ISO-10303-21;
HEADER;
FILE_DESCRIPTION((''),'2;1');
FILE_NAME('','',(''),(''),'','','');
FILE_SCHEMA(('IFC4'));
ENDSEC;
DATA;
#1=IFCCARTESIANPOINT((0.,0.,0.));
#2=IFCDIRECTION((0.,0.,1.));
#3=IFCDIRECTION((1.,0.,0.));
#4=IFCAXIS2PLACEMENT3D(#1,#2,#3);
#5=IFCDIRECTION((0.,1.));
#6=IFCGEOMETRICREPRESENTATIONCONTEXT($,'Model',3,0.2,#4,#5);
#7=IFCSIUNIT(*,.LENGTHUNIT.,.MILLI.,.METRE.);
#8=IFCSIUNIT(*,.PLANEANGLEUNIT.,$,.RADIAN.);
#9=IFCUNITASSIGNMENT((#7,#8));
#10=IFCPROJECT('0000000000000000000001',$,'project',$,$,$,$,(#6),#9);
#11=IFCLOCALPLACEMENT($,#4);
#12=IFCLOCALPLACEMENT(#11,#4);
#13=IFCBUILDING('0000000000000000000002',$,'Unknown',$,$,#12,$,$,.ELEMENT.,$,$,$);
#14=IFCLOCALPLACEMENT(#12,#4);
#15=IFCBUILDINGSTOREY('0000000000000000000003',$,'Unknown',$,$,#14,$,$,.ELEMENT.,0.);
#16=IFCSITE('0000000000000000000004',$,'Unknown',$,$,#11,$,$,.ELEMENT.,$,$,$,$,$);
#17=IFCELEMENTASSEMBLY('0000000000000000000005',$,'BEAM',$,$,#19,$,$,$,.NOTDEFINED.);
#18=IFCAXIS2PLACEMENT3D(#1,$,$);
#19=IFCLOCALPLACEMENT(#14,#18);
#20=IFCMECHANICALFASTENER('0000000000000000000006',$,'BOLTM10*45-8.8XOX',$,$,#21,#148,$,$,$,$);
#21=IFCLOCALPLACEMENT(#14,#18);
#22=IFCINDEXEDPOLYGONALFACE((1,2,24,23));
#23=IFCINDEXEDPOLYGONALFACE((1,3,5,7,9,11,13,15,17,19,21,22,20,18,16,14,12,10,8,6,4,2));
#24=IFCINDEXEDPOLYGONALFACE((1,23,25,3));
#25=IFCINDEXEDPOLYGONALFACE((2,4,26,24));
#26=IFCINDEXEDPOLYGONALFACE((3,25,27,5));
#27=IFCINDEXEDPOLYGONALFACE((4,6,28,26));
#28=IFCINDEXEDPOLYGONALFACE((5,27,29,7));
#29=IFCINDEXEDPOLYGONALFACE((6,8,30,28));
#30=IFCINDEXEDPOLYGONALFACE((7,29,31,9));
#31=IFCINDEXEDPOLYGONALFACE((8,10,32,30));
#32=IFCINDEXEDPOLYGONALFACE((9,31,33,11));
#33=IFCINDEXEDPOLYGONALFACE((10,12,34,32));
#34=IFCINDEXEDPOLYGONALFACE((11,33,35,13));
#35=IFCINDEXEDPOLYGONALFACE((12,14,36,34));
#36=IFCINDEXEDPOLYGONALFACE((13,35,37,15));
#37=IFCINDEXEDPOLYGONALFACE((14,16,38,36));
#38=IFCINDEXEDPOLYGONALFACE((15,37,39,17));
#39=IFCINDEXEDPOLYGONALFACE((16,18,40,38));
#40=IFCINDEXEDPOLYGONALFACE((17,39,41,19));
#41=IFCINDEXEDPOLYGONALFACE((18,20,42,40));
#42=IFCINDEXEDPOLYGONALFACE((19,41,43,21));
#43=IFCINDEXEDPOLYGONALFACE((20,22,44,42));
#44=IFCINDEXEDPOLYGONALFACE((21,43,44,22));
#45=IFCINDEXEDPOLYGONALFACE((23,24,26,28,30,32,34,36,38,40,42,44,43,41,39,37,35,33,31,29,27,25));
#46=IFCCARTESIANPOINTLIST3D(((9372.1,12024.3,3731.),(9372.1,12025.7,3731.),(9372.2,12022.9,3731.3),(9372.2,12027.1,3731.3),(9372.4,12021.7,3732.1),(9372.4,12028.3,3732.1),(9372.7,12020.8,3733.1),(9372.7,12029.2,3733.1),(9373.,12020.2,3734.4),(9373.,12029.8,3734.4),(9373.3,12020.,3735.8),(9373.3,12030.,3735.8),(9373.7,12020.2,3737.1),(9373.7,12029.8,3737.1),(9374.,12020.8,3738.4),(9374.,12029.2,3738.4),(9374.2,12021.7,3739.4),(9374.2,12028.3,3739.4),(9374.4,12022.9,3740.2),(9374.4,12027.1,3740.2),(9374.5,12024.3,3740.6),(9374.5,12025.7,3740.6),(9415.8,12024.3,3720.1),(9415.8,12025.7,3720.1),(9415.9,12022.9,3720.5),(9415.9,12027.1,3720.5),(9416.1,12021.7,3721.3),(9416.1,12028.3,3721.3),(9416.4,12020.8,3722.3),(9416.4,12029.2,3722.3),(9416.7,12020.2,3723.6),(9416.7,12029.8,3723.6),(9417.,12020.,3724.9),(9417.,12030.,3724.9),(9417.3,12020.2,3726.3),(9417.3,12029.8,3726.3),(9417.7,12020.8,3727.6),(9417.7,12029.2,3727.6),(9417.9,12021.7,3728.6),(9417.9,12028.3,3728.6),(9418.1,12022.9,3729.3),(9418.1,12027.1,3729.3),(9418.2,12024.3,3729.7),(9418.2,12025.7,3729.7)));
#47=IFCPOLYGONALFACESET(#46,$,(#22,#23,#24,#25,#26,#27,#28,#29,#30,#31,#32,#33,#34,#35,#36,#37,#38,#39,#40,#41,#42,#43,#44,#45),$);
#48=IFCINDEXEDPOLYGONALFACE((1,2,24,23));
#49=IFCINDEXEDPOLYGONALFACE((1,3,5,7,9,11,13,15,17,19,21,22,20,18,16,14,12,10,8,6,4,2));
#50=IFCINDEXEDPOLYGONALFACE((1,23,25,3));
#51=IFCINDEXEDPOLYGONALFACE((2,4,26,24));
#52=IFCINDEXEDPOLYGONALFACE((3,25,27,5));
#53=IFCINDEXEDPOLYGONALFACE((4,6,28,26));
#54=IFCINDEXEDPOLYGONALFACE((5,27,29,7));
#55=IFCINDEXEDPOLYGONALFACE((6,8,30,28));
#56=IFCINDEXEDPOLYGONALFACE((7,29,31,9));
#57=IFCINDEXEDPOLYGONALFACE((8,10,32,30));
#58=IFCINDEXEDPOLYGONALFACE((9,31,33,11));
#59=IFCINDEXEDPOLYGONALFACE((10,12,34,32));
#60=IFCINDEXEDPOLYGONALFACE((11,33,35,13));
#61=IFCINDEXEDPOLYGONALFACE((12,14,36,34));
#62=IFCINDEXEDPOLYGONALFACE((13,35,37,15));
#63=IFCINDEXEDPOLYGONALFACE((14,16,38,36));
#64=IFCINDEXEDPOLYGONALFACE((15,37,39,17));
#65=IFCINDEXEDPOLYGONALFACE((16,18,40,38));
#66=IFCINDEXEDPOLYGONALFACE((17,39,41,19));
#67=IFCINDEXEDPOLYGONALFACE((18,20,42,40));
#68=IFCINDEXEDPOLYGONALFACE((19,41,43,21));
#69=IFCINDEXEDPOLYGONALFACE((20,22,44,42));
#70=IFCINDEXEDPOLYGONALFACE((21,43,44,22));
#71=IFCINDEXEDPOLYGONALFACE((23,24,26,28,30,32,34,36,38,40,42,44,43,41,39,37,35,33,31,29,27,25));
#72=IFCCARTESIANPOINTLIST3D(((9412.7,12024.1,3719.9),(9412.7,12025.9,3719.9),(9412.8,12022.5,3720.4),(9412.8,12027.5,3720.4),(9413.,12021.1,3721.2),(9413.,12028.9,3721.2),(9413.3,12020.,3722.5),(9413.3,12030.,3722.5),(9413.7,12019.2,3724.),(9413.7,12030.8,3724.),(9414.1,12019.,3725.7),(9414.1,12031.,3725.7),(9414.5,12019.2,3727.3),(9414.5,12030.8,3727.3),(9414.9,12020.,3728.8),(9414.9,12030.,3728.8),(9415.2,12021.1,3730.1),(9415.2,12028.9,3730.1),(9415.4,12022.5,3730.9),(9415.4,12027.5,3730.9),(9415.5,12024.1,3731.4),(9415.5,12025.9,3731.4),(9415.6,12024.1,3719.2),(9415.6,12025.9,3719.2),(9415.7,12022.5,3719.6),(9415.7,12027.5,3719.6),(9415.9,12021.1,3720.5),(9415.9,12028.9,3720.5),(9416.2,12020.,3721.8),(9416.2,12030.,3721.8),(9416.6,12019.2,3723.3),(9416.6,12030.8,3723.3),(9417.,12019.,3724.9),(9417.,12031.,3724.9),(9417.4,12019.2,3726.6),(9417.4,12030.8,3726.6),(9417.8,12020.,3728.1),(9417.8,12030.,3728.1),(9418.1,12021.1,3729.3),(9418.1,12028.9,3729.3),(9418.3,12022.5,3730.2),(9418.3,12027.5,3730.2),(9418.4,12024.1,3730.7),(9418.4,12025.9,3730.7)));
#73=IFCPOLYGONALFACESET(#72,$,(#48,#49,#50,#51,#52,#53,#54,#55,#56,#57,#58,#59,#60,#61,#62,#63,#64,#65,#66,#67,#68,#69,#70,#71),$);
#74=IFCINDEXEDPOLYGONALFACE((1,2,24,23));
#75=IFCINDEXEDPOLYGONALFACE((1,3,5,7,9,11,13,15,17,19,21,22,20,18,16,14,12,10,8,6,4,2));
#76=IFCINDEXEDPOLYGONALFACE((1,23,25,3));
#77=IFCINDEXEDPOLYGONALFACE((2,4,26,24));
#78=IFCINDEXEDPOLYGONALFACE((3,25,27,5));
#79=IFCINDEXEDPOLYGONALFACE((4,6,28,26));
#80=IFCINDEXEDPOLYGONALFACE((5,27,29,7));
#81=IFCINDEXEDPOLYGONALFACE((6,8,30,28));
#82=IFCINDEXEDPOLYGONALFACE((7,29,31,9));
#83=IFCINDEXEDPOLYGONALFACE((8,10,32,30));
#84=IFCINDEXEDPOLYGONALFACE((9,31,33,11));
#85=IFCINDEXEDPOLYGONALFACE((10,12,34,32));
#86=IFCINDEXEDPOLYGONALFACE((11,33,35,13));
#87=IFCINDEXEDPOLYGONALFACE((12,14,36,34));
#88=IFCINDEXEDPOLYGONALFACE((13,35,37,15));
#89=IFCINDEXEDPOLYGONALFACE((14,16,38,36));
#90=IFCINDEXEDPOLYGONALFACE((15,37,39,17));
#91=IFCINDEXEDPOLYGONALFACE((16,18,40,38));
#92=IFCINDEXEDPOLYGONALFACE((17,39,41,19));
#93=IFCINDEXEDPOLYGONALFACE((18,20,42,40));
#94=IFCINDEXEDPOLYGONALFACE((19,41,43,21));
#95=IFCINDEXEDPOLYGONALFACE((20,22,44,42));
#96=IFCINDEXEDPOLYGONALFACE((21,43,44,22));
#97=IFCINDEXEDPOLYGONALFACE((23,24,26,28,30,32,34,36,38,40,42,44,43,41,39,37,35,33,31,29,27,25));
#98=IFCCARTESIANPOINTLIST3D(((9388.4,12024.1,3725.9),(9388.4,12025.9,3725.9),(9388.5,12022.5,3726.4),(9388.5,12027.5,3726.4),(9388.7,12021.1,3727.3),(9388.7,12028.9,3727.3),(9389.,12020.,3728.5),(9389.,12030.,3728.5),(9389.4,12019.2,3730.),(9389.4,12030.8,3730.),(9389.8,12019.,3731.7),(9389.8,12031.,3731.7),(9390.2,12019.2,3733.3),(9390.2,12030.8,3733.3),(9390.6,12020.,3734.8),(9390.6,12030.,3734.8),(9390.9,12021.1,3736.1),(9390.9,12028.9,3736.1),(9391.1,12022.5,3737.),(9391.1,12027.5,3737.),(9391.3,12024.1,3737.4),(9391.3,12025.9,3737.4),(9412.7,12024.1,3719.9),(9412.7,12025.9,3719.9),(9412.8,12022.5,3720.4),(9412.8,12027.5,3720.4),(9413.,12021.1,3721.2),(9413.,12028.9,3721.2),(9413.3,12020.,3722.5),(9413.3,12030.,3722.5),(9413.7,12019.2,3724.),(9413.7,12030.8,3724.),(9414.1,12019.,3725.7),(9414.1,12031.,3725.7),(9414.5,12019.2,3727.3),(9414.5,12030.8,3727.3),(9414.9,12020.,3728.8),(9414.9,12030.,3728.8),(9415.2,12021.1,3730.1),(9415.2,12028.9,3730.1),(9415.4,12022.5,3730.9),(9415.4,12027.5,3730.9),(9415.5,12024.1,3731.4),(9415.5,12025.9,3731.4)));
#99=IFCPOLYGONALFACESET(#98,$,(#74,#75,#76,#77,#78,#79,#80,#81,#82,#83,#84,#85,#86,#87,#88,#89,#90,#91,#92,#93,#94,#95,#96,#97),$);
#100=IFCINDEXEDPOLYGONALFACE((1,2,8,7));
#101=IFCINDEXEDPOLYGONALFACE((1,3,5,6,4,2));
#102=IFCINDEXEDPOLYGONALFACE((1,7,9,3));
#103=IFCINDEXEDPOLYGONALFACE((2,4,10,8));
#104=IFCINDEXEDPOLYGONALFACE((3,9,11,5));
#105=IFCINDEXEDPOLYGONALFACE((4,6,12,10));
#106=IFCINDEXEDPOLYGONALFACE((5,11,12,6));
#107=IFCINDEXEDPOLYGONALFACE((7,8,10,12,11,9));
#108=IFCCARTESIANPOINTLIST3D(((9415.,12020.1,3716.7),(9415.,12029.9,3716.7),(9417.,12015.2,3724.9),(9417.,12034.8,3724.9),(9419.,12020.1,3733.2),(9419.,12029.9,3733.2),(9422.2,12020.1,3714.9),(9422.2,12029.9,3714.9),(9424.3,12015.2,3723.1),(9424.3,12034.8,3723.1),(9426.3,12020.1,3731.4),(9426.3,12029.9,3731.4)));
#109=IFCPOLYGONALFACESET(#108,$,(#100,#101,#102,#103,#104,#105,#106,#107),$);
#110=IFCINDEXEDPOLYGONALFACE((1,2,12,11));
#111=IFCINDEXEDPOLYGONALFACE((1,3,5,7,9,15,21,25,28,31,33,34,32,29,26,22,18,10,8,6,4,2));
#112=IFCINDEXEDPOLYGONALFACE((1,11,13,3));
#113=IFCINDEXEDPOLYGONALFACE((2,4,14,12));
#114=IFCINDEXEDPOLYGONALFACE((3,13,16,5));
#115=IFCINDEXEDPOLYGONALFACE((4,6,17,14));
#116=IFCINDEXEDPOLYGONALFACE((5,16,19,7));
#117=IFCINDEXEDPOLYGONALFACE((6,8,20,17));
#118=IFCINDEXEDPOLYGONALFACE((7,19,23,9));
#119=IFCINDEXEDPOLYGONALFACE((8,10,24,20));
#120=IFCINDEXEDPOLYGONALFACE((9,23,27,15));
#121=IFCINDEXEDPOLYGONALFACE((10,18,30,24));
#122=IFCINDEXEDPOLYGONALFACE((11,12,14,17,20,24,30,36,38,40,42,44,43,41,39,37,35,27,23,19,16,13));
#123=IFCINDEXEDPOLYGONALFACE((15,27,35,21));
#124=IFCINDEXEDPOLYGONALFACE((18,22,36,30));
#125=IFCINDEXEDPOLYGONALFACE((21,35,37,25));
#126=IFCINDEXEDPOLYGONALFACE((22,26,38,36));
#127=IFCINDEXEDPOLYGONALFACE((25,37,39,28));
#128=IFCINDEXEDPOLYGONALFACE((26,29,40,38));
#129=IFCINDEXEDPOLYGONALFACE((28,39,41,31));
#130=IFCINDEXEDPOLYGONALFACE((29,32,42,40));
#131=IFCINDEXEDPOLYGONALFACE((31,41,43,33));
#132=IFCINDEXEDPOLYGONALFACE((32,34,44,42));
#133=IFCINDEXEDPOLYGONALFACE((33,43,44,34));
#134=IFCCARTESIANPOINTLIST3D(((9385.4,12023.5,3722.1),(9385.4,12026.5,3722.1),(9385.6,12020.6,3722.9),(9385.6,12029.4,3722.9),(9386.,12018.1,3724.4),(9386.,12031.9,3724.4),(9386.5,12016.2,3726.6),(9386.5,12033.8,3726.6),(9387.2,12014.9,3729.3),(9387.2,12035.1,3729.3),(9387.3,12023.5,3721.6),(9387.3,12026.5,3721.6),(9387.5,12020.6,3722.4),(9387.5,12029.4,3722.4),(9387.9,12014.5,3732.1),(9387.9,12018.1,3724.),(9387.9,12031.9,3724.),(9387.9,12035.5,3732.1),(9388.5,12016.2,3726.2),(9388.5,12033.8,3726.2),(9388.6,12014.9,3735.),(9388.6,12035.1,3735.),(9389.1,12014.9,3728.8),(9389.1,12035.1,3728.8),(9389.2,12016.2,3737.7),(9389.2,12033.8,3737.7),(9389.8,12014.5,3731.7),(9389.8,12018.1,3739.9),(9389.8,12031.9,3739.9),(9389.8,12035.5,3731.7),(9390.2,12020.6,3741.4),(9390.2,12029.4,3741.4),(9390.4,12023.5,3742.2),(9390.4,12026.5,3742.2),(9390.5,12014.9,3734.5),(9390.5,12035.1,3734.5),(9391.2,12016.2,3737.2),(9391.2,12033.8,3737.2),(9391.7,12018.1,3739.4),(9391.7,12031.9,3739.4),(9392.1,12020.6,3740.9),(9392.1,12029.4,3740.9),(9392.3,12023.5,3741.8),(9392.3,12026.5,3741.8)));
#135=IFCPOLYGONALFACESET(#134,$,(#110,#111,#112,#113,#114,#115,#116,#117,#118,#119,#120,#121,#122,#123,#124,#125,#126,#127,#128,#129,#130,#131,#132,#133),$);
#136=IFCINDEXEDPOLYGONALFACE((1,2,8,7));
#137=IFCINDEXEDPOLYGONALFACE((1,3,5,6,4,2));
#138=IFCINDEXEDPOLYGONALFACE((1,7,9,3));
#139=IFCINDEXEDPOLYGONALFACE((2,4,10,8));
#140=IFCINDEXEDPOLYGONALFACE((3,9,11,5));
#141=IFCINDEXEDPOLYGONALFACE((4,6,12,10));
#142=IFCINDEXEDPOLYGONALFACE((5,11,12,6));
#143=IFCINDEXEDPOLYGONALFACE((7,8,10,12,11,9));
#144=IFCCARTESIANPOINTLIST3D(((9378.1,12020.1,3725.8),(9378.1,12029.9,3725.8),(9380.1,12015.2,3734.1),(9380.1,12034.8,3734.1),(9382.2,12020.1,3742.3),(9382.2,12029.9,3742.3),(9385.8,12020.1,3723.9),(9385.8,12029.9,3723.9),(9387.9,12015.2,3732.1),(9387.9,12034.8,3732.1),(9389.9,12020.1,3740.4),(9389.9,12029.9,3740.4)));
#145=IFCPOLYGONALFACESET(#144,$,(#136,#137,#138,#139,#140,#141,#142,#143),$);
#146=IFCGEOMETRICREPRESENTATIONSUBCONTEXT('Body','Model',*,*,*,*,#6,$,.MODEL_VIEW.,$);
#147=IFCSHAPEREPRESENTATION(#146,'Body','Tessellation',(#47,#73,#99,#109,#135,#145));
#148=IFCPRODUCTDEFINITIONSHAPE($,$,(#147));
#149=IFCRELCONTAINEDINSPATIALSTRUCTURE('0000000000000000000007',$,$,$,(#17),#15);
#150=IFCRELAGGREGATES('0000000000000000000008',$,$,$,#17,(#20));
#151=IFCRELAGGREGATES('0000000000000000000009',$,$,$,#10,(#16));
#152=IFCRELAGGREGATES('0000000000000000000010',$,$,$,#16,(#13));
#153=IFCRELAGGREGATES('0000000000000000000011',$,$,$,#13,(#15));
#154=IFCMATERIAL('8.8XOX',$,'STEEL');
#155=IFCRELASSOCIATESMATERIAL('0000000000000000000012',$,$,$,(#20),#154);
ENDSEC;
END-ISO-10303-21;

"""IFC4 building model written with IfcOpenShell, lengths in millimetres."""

from ifc_helpers import new_model, si_unit, direction, frame, origin_with_axes, place, context, subcontext, project, spatial, line, arc, indexed_curve, outline, extrude, source, transform, mapped, material, element, aggregate, save


model = new_model("IFC4")

# Units and contexts
model_context = context("Model", 3, precision=0.2, world=origin_with_axes(), true_north=direction((0.0, 1.0)))
body_context = subcontext(model_context, "Body", "Model", "MODEL_VIEW")
ifc_project = project(units=[si_unit("LENGTHUNIT", "METRE", prefix="MILLI"), si_unit("PLANEANGLEUNIT", "RADIAN")], contexts=[model_context])

# Site, building, storey
site_placement = place(None, origin_with_axes())
site = spatial("IfcSite", under=ifc_project, at=site_placement, Name="Unknown", CompositionType="ELEMENT")
building_placement = place(site_placement, origin_with_axes())
building = spatial("IfcBuilding", under=site, at=building_placement, Name="Unknown", CompositionType="ELEMENT")
storey_placement = place(building_placement, origin_with_axes())
storey = spatial("IfcBuildingStorey", under=building, at=storey_placement, Name="Unknown", CompositionType="ELEMENT", Elevation=0.0)

# Shared definitions
ifc_material_1 = material(Name="8.8XOX", Category="STEEL")

# Element assembly, mechanical fastener
shared_shape_1 = source(origin_with_axes(), body_context, "Body", "SweptSolid", [
    extrude(outline(indexed_curve([(5.0, 0.0), (0.0, 5.0), (-5.0, 0.0), (0.0, -5.0)], segments=[arc(1, 2, 3), arc(3, 4, 1)])), frame((0.0, 0.0, 3.8), z_axis=(0.0, 0.0, -1.0), x_axis=(0.0, 1.0, 0.0)), (0.0, 0.0, 1.0), 45.0),
    extrude(outline(indexed_curve([(6.0, 0.0), (0.0, 6.0), (-6.0, 0.0), (0.0, -6.0)], segments=[arc(1, 2, 3), arc(3, 4, 1)])), frame((0.0, 0.0, 3.8), z_axis=(0.0, 0.0, -1.0), x_axis=(0.0, 1.0, 0.0)), (0.0, 0.0, 1.0), 3.0),
    extrude(outline(indexed_curve([(6.0, 0.0), (0.0, 6.0), (-6.0, 0.0), (0.0, -6.0)], segments=[arc(1, 2, 3), arc(3, 4, 1)])), frame((0.0, 0.0, 0.8), z_axis=(0.0, 0.0, -1.0), x_axis=(0.0, 1.0, 0.0)), (0.0, 0.0, 1.0), 25.0),
    extrude(outline(indexed_curve([(9.8, 0.0), (4.9, 8.5), (-4.9, 8.5), (-9.8, 0.0), (-4.9, -8.5), (4.9, -8.5)], segments=[line(1, 2, 3, 4, 5, 6, 1)])), frame((0.0, 0.0, 11.2), z_axis=(0.0, 0.0, -1.0), x_axis=(0.0, 1.0, 0.0)), (0.0, 0.0, 1.0), 7.5),
    extrude(outline(indexed_curve([(10.5, 0.0), (0.0, 10.5), (-10.5, 0.0), (0.0, -10.5)], segments=[arc(1, 2, 3), arc(3, 4, 1)])), frame((0.0, 0.0, -24.2), z_axis=(0.0, 0.0, -1.0), x_axis=(0.0, 1.0, 0.0)), (0.0, 0.0, 1.0), 2.0),
    extrude(outline(indexed_curve([(9.8, 0.0), (4.9, 8.5), (-4.9, 8.5), (-9.8, 0.0), (-4.9, -8.5), (4.9, -8.5)], segments=[line(1, 2, 3, 4, 5, 6, 1)])), frame((0.0, 0.0, -26.2), z_axis=(0.0, 0.0, -1.0), x_axis=(0.0, 1.0, 0.0)), (0.0, 0.0, 1.0), 8.0),
])
assembly_1_placement = place(storey_placement, frame((9403.2, 12000.0, 3733.5), z_axis=(0.970613, 0.0, -0.240648), x_axis=(0.0, 1.0, 0.0)))
assembly_1 = element("IfcElementAssembly", 1, at=assembly_1_placement, inside=storey, Name="BEAM", PredefinedType="NOTDEFINED")
mechanical_fastener_1_placement = place(assembly_1_placement, frame((25.0, -5.0, 11.8), z_axis=(0.0, 0.0, 1.0), x_axis=(0.0, 1.0, 0.0)))
mechanical_fastener_1 = element("IfcMechanicalFastener", 2, at=mechanical_fastener_1_placement, material=ifc_material_1, Name="BOLTM10*45-8.8XOX", context=body_context, shape_type="MappedRepresentation", body=[
    mapped(shared_shape_1, transform((0.0, 0.0, 0.0))),
])
aggregate(assembly_1, [mechanical_fastener_1])

save(model, "model.ifc")
